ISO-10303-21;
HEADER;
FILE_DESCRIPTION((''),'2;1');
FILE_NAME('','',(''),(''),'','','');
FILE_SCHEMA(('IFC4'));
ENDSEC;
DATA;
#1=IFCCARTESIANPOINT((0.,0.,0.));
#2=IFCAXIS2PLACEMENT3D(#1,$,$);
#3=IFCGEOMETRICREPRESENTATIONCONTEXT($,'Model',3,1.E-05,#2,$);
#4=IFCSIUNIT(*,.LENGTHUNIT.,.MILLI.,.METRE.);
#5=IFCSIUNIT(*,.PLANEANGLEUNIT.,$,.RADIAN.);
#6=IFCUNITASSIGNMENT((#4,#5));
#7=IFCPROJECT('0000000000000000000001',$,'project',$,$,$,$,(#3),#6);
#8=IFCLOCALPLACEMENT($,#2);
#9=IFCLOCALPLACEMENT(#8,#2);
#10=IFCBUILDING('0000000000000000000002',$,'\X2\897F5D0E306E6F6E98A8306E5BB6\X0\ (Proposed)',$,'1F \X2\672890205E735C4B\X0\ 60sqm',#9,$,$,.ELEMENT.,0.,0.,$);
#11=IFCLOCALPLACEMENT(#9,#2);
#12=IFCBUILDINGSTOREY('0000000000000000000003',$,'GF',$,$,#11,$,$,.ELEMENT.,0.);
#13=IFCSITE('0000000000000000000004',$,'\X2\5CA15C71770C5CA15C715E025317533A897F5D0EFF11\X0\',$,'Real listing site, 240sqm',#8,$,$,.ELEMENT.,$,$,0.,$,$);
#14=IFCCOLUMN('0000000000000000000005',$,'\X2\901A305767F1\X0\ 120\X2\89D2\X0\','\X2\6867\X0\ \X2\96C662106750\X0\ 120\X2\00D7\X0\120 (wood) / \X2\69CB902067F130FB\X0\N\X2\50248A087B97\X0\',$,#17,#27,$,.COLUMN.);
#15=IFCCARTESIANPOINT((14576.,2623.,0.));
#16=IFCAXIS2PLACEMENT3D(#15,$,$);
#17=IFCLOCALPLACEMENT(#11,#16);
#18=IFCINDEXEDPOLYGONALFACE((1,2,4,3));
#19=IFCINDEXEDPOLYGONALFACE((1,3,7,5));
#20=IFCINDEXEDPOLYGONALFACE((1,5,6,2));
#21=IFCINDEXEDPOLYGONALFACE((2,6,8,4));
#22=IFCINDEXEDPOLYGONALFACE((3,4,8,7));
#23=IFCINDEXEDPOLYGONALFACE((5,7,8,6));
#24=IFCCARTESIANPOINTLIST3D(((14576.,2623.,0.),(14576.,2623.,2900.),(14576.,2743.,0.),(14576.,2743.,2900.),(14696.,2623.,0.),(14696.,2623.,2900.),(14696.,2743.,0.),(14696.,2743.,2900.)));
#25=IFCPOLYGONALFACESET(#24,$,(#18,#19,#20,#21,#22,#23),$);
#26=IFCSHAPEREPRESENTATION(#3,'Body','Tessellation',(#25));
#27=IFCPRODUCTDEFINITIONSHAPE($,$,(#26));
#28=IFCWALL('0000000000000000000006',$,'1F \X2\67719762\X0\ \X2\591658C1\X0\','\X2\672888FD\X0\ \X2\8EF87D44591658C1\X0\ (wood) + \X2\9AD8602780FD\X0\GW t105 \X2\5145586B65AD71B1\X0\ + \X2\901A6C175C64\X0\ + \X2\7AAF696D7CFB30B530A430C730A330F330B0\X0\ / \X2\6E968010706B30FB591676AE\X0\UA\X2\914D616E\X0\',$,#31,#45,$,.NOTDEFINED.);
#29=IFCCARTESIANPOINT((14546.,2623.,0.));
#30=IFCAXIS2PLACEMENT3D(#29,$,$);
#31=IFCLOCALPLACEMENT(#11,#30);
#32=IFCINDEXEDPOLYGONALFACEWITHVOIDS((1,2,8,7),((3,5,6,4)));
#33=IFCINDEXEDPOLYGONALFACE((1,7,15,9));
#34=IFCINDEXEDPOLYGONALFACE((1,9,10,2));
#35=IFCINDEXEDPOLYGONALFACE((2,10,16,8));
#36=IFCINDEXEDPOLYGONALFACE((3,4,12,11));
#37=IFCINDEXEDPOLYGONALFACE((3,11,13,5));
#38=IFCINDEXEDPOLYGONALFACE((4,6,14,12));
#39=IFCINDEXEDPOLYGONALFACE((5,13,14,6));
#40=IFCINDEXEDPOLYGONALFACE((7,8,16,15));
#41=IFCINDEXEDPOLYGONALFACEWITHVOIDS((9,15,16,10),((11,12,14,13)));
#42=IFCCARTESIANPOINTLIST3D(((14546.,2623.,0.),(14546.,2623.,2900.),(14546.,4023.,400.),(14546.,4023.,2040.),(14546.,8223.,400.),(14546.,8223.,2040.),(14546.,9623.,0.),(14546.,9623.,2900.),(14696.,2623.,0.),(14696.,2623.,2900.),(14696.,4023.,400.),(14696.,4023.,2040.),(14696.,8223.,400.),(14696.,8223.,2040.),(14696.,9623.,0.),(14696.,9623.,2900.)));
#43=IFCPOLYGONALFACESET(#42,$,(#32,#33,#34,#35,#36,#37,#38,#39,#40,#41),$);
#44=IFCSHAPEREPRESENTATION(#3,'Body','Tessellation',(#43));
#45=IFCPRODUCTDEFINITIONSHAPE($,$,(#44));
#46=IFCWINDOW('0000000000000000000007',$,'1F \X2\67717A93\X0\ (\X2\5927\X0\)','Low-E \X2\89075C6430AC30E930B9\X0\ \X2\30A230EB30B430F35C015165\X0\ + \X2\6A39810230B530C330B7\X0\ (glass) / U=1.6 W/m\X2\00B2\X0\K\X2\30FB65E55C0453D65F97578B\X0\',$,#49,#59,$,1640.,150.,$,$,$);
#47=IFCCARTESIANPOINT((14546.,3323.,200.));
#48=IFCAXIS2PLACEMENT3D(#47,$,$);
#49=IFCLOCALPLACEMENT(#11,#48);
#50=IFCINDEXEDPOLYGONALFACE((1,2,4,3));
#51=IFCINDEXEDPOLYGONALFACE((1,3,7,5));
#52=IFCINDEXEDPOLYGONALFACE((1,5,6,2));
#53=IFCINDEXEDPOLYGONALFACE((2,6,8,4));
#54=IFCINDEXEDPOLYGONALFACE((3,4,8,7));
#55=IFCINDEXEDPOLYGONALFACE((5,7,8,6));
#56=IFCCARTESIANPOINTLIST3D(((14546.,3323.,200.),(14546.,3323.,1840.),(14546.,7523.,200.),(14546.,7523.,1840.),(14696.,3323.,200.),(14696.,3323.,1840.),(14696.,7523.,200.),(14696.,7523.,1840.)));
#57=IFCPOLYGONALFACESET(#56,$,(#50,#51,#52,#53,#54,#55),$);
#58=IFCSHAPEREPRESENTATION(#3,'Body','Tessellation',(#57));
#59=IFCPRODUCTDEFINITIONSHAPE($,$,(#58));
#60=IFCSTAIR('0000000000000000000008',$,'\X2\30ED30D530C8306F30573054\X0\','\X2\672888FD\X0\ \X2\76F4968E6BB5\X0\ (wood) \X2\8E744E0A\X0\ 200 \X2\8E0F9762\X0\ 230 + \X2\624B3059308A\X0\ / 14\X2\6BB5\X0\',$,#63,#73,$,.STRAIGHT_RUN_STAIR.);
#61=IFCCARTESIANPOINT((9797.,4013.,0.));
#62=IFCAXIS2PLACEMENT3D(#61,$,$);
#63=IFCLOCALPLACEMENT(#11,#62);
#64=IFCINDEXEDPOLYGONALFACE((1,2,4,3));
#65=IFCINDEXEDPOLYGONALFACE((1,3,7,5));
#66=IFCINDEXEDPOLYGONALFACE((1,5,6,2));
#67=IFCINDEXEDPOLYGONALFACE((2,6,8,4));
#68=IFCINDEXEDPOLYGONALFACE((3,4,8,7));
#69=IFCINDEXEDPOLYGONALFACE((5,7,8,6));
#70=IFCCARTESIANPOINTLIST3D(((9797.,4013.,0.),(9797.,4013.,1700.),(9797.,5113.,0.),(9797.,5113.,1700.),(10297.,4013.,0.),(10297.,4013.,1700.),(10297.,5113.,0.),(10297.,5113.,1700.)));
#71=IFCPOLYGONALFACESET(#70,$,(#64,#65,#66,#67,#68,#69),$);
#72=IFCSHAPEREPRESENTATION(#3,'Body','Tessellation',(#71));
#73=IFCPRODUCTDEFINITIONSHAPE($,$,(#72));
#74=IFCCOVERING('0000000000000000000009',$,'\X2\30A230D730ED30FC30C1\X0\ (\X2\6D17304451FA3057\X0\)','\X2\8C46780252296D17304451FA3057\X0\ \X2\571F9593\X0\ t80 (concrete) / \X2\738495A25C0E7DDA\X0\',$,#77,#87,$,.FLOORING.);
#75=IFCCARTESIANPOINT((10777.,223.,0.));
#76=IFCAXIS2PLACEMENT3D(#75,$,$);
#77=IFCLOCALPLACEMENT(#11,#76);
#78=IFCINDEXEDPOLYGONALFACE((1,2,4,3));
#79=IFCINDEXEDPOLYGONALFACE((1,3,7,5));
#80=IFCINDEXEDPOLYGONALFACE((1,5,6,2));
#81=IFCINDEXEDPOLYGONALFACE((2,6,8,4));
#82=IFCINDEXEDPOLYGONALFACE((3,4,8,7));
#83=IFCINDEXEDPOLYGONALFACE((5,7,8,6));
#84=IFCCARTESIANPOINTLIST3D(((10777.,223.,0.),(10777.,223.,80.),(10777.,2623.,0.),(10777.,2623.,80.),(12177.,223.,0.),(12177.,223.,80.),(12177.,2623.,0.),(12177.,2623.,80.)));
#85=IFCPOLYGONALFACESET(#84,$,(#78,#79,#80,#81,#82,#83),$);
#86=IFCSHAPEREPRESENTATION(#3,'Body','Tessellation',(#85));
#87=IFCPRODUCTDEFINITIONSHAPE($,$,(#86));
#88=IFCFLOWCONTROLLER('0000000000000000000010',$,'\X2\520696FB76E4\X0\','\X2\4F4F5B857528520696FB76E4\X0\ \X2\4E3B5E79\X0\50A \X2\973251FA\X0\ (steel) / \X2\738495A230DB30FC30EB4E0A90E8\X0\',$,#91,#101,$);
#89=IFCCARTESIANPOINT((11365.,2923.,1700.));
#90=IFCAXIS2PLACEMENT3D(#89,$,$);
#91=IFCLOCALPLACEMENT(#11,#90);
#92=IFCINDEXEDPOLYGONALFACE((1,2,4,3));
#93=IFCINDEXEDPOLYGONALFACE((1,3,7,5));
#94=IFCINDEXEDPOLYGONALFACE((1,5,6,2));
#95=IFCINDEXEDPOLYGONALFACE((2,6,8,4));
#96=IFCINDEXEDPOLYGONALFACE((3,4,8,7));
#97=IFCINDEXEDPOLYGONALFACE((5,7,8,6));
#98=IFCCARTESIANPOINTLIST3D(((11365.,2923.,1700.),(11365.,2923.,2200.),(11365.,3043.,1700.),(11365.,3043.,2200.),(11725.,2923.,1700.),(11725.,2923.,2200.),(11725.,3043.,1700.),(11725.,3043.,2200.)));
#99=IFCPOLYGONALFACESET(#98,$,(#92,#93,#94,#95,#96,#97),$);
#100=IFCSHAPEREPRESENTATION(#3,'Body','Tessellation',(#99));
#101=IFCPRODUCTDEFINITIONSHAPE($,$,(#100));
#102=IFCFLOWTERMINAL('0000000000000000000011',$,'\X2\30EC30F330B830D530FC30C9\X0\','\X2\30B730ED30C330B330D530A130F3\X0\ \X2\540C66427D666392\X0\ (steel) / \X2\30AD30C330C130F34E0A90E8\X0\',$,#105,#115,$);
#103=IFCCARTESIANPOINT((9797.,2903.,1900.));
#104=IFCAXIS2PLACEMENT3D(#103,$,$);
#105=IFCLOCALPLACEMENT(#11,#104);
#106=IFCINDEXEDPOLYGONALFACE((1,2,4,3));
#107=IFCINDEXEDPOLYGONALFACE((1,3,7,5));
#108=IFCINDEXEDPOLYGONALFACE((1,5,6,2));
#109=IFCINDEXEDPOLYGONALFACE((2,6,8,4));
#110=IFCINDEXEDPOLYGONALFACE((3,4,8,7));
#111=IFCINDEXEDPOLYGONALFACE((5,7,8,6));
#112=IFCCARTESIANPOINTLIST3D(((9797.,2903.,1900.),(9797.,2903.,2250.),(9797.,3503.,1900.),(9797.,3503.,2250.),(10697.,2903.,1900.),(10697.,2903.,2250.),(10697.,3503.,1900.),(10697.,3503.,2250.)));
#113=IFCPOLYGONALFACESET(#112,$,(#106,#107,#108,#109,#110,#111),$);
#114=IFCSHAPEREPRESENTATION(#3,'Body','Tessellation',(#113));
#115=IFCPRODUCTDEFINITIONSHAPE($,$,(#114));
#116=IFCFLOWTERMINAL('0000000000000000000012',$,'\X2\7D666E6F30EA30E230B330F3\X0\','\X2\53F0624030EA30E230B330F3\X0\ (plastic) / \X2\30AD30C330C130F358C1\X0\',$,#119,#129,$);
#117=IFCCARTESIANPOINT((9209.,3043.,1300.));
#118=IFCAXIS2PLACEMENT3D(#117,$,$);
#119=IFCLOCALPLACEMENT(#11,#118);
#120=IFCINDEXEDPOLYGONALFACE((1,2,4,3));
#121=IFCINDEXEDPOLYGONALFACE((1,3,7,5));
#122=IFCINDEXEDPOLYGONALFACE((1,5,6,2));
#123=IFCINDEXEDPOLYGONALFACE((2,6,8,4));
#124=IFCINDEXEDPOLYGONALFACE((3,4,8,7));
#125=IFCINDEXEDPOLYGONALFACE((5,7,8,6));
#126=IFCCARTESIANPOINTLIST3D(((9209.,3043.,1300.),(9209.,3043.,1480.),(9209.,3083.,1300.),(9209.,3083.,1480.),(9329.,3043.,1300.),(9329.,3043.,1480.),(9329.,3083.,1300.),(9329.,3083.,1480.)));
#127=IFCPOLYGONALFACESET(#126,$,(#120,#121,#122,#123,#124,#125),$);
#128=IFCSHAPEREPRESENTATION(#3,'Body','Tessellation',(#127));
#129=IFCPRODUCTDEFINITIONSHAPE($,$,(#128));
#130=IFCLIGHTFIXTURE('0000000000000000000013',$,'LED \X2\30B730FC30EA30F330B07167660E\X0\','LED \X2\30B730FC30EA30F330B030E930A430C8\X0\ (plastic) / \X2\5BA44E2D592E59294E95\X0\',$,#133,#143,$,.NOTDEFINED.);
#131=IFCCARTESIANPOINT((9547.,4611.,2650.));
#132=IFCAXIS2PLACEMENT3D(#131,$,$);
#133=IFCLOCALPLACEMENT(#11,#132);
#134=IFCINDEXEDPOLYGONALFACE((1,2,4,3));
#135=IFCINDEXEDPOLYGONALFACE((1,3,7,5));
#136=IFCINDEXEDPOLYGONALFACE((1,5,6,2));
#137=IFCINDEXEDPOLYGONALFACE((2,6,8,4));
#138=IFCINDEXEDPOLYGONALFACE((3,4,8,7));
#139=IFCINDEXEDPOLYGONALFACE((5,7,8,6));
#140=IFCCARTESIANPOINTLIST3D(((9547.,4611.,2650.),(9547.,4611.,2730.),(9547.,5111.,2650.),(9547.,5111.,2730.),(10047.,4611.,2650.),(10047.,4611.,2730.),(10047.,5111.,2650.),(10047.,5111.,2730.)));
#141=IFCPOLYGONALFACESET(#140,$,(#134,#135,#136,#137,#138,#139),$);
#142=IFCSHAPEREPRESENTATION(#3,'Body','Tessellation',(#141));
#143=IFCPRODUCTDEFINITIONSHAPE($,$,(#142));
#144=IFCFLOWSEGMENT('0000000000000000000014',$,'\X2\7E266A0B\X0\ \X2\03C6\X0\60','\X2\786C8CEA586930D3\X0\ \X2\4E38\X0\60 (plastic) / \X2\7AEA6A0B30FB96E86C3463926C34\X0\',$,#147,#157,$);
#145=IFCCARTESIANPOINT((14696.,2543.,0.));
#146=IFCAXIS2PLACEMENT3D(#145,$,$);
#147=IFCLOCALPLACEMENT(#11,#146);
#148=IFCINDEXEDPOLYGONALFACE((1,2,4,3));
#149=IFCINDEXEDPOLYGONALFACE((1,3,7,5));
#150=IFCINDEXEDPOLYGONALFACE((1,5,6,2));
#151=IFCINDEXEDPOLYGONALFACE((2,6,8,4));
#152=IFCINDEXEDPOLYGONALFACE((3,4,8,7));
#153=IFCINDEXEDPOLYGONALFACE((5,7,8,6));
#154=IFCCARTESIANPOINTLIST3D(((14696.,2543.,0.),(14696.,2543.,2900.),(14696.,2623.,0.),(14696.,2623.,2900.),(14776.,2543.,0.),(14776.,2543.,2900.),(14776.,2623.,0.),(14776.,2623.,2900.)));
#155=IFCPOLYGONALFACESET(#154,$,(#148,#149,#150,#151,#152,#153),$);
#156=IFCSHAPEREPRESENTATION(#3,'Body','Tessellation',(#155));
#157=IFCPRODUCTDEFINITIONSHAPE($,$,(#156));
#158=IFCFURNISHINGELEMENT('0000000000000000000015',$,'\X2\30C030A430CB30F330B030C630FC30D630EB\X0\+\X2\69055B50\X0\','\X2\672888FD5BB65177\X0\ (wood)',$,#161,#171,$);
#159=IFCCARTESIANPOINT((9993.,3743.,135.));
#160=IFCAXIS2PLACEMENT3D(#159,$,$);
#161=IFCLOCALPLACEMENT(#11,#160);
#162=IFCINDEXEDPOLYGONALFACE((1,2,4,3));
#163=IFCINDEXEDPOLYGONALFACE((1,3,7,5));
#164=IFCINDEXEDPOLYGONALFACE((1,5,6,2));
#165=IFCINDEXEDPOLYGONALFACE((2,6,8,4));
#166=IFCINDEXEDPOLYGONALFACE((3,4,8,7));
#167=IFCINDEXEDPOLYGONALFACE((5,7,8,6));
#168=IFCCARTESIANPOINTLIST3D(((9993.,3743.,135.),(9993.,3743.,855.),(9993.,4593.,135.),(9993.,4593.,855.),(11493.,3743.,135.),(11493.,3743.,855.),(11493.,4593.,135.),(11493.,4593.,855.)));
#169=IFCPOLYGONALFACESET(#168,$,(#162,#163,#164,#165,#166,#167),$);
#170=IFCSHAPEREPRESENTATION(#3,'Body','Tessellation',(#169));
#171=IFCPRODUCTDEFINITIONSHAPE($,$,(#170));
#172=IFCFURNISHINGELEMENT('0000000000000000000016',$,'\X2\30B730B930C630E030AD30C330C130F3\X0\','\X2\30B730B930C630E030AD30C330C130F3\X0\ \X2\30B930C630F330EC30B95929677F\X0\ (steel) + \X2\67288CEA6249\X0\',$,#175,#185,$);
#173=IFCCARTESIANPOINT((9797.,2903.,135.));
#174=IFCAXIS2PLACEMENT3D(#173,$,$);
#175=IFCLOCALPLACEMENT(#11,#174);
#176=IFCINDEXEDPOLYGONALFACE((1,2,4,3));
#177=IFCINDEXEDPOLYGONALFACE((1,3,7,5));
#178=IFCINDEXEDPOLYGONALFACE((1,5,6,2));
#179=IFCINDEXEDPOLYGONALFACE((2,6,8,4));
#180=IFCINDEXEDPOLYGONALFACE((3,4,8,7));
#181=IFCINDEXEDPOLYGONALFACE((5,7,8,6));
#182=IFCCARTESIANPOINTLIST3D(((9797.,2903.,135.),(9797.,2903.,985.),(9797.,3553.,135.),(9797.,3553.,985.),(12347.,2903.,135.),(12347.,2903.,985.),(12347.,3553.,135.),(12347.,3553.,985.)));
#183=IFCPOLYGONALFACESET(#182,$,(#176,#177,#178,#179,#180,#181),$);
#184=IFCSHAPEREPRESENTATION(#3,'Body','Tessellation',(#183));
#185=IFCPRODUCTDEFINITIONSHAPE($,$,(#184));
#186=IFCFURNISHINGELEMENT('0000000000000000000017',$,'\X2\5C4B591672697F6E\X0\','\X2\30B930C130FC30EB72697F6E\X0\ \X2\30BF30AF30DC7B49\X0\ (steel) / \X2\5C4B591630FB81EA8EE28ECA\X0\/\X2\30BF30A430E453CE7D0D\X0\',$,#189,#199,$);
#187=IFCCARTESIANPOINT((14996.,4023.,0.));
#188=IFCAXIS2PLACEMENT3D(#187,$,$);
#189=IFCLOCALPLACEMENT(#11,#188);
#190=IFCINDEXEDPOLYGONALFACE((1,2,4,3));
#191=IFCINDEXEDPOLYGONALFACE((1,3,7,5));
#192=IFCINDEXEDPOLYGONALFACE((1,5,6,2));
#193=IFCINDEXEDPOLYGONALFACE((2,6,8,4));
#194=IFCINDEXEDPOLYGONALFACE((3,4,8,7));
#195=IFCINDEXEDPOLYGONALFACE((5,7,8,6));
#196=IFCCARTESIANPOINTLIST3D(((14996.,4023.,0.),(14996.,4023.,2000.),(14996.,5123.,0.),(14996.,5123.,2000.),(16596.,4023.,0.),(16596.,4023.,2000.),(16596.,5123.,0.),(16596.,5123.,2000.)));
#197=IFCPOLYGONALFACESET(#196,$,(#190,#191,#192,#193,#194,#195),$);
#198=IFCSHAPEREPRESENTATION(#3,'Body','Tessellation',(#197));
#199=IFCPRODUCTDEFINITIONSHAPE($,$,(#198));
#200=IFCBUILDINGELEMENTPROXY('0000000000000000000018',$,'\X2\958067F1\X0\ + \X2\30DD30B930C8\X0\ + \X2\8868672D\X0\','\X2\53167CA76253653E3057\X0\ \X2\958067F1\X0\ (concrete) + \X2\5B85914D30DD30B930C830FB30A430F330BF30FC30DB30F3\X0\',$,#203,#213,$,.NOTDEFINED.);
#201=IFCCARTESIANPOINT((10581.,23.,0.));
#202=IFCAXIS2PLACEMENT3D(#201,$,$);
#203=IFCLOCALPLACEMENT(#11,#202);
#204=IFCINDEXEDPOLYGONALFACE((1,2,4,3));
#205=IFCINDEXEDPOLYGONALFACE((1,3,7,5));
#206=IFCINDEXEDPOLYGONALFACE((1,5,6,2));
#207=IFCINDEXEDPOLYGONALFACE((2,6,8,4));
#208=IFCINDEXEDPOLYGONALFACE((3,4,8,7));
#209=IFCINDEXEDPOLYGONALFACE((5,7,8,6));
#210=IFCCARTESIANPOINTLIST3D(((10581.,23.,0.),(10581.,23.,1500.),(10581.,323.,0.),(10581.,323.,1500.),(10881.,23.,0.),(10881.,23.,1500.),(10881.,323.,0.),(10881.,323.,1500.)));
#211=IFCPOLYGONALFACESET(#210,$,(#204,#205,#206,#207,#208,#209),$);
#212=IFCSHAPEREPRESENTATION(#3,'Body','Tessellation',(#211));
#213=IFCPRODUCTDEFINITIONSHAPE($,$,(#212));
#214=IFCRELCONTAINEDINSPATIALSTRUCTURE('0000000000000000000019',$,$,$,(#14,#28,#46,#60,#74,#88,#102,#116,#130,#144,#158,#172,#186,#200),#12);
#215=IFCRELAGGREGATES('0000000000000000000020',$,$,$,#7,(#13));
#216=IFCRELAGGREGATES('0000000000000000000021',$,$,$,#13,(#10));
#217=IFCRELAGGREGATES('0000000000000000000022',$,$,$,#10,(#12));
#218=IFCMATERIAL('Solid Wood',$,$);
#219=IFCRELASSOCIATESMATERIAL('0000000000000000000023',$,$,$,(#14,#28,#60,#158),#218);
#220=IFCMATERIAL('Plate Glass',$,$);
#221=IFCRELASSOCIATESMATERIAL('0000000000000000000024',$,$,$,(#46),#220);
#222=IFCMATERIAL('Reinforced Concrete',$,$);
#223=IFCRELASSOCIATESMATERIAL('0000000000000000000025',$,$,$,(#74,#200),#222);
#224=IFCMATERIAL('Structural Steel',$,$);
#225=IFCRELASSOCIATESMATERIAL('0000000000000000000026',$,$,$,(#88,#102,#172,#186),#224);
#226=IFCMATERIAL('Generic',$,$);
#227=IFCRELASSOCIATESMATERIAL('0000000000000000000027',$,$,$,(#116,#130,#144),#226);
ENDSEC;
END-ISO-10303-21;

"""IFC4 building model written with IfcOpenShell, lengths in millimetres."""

from ifc_helpers import new_model, si_unit, frame, frame_2d, origin, place, context, project, spatial, rectangle, extrude, material, element, fill, save


model = new_model("IFC4")

# Units and contexts
model_context = context("Model", 3, precision=1e-05, world=origin())
ifc_project = project(units=[si_unit("LENGTHUNIT", "METRE", prefix="MILLI"), si_unit("PLANEANGLEUNIT", "RADIAN")], contexts=[model_context])

# Site, building, storey
site_placement = place(None, origin())
site = spatial("IfcSite", under=ifc_project, at=site_placement, Name="岡山県岡山市北区西崎１", ObjectType="Real listing site, 240sqm", CompositionType="ELEMENT", RefElevation=0.0)
building_placement = place(site_placement, origin())
building = spatial("IfcBuilding", under=site, at=building_placement, Name="西崎の潮風の家 (Proposed)", ObjectType="1F 木造平屋 60sqm", CompositionType="ELEMENT", ElevationOfRefHeight=0.0, ElevationOfTerrain=0.0)
storey_placement = place(building_placement, origin())
storey = spatial("IfcBuildingStorey", under=building, at=storey_placement, Name="GF", CompositionType="ELEMENT", Elevation=0.0)

# Column
ifc_material_1 = material(Name="Solid Wood")
column_1_placement = place(storey_placement, frame((14576.0, 2623.0, 0.0)))
element("IfcColumn", 1, at=column_1_placement, inside=storey, material=ifc_material_1, Name="通し柱 120角", Description="桧 集成材 120×120 (wood) / 構造柱・N値計算", PredefinedType="COLUMN", context=model_context, shape_type="SweptSolid", body=[
    extrude(rectangle(XDim=120.0, YDim=120.0, at=frame_2d((60.0, 60.0))), frame((14576.0, 2623.0, 0.0)), (0.0, 0.0, 1.0), 2900.0),
])

# Wall, opening, window
wall_1_placement = place(storey_placement, frame((14546.0, 2623.0, 0.0)))
wall_1 = element("IfcWall", 2, at=wall_1_placement, inside=storey, material=ifc_material_1, Name="1F 東面 外壁", Description="木製 軸組外壁 (wood) + 高性能GW t105 充填断熱 + 通気層 + 窯業系サイディング / 準耐火・外皮UA配慮", PredefinedType="NOTDEFINED", context=model_context, shape_type="SweptSolid", body=[
    extrude(rectangle(XDim=150.0, YDim=7000.0, at=frame_2d((75.0, 3500.0))), frame((14546.0, 2623.0, 0.0)), (0.0, 0.0, 1.0), 2900.0),
])
opening_placement = place(storey_placement, frame((14546.0, 3323.0, 200.0)))
opening = element("IfcOpeningElement", 3, at=opening_placement, cuts=wall_1, PredefinedType="NOTDEFINED", context=model_context, shape_type="SweptSolid", body=[
    extrude(rectangle(XDim=150.0, YDim=4200.0, at=frame_2d((75.0, 2100.0))), frame((14546.0, 3323.0, 200.0)), (0.0, 0.0, 1.0), 1640.0),
])
ifc_material_2 = material(Name="Plate Glass")
window_placement = place(storey_placement, frame((14546.0, 3323.0, 200.0)))
window = element("IfcWindow", 4, at=window_placement, inside=storey, material=ifc_material_2, Name="1F 東窓 (大)", Description="Low-E 複層ガラス アルゴン封入 + 樹脂サッシ (glass) / U=1.6 W/m²K・日射取得型", OverallHeight=1640.0, OverallWidth=150.0, context=model_context, shape_type="SweptSolid", body=[
    extrude(rectangle(XDim=150.0, YDim=4200.0, at=frame_2d((75.0, 2100.0))), frame((14546.0, 3323.0, 200.0)), (0.0, 0.0, 1.0), 1640.0),
])
fill(opening, window)

# Stair
stair_placement = place(storey_placement, frame((9797.0, 4013.0, 0.0)))
element("IfcStair", 5, at=stair_placement, inside=storey, material=ifc_material_1, Name="ロフトはしご", Description="木製 直階段 (wood) 蹴上 200 踏面 230 + 手すり / 14段", PredefinedType="STRAIGHT_RUN_STAIR", context=model_context, shape_type="SweptSolid", body=[
    extrude(rectangle(XDim=500.0, YDim=1100.0, at=frame_2d((250.0, 550.0))), frame((9797.0, 4013.0, 0.0)), (0.0, 0.0, 1.0), 1700.0),
])

# Covering
ifc_material_3 = material(Name="Reinforced Concrete")
covering_placement = place(storey_placement, frame((10777.0, 223.0, 0.0)))
element("IfcCovering", 6, at=covering_placement, inside=storey, material=ifc_material_3, Name="アプローチ (洗い出し)", Description="豆砂利洗い出し 土間 t80 (concrete) / 玄関導線", PredefinedType="FLOORING", context=model_context, shape_type="SweptSolid", body=[
    extrude(rectangle(XDim=1400.0, YDim=2400.0, at=frame_2d((700.0, 1200.0))), frame((10777.0, 223.0, 0.0)), (0.0, 0.0, 1.0), 80.0),
])

# Flow controller
ifc_material_4 = material(Name="Structural Steel")
flow_controller_placement = place(storey_placement, frame((11365.0, 2923.0, 1700.0)))
element("IfcFlowController", 7, at=flow_controller_placement, inside=storey, material=ifc_material_4, Name="分電盤", Description="住宅用分電盤 主幹50A 露出 (steel) / 玄関ホール上部", context=model_context, shape_type="SweptSolid", body=[
    extrude(rectangle(XDim=360.0, YDim=120.0, at=frame_2d((180.0, 60.0))), frame((11365.0, 2923.0, 1700.0)), (0.0, 0.0, 1.0), 500.0),
])

# Flow terminals
flow_terminal_1_placement = place(storey_placement, frame((9797.0, 2903.0, 1900.0)))
element("IfcFlowTerminal", 8, at=flow_terminal_1_placement, inside=storey, material=ifc_material_4, Name="レンジフード", Description="シロッコファン 同時給排 (steel) / キッチン上部", context=model_context, shape_type="SweptSolid", body=[
    extrude(rectangle(XDim=900.0, YDim=600.0, at=frame_2d((450.0, 300.0))), frame((9797.0, 2903.0, 1900.0)), (0.0, 0.0, 1.0), 350.0),
])
ifc_material_5 = material(Name="Generic")
flow_terminal_2_placement = place(storey_placement, frame((9209.0, 3043.0, 1300.0)))
element("IfcFlowTerminal", 9, at=flow_terminal_2_placement, inside=storey, material=ifc_material_5, Name="給湯リモコン", Description="台所リモコン (plastic) / キッチン壁", context=model_context, shape_type="SweptSolid", body=[
    extrude(rectangle(XDim=120.0, YDim=40.0, at=frame_2d((60.0, 20.0))), frame((9209.0, 3043.0, 1300.0)), (0.0, 0.0, 1.0), 180.0),
])

# Light fixture
light_fixture_placement = place(storey_placement, frame((9547.0, 4611.0, 2650.0)))
element("IfcLightFixture", 10, at=light_fixture_placement, inside=storey, material=ifc_material_5, Name="LED シーリング照明", Description="LED シーリングライト (plastic) / 室中央天井", PredefinedType="NOTDEFINED", context=model_context, shape_type="SweptSolid", body=[
    extrude(rectangle(XDim=500.0, YDim=500.0, at=frame_2d((250.0, 250.0))), frame((9547.0, 4611.0, 2650.0)), (0.0, 0.0, 1.0), 80.0),
])

# Flow segment
flow_segment_placement = place(storey_placement, frame((14696.0, 2543.0, 0.0)))
element("IfcFlowSegment", 11, at=flow_segment_placement, inside=storey, material=ifc_material_5, Name="縦樋 φ60", Description="硬質塩ビ 丸60 (plastic) / 竪樋・雨水排水", context=model_context, shape_type="SweptSolid", body=[
    extrude(rectangle(XDim=80.0, YDim=80.0, at=frame_2d((40.0, 40.0))), frame((14696.0, 2543.0, 0.0)), (0.0, 0.0, 1.0), 2900.0),
])

# Furnishing elements
furnishing_1_placement = place(storey_placement, frame((9993.0, 3743.0, 135.0)))
element("IfcFurnishingElement", 12, at=furnishing_1_placement, inside=storey, material=ifc_material_1, Name="ダイニングテーブル+椅子", Description="木製家具 (wood)", context=model_context, shape_type="SweptSolid", body=[
    extrude(rectangle(XDim=1500.0, YDim=850.0, at=frame_2d((750.0, 425.0))), frame((9993.0, 3743.0, 135.0)), (0.0, 0.0, 1.0), 720.0),
])
furnishing_2_placement = place(storey_placement, frame((9797.0, 2903.0, 135.0)))
element("IfcFurnishingElement", 13, at=furnishing_2_placement, inside=storey, material=ifc_material_4, Name="システムキッチン", Description="システムキッチン ステンレス天板 (steel) + 木質扉", context=model_context, shape_type="SweptSolid", body=[
    extrude(rectangle(XDim=2550.0, YDim=650.0, at=frame_2d((1275.0, 325.0))), frame((9797.0, 2903.0, 135.0)), (0.0, 0.0, 1.0), 850.0),
])
furnishing_3_placement = place(storey_placement, frame((14996.0, 4023.0, 0.0)))
element("IfcFurnishingElement", 14, at=furnishing_3_placement, inside=storey, material=ifc_material_4, Name="屋外物置", Description="スチール物置 タクボ等 (steel) / 屋外・自転車/タイヤ収納", context=model_context, shape_type="SweptSolid", body=[
    extrude(rectangle(XDim=1600.0, YDim=1100.0, at=frame_2d((800.0, 550.0))), frame((14996.0, 4023.0, 0.0)), (0.0, 0.0, 1.0), 2000.0),
])

# Building element proxy
proxy_placement = place(storey_placement, frame((10581.0, 23.0, 0.0)))
element("IfcBuildingElementProxy", 15, at=proxy_placement, inside=storey, material=ifc_material_3, Name="門柱 + ポスト + 表札", Description="化粧打放し 門柱 (concrete) + 宅配ポスト・インターホン", PredefinedType="NOTDEFINED", context=model_context, shape_type="SweptSolid", body=[
    extrude(rectangle(XDim=300.0, YDim=300.0, at=frame_2d((150.0, 150.0))), frame((10581.0, 23.0, 0.0)), (0.0, 0.0, 1.0), 1500.0),
])

save(model, "model.ifc")
